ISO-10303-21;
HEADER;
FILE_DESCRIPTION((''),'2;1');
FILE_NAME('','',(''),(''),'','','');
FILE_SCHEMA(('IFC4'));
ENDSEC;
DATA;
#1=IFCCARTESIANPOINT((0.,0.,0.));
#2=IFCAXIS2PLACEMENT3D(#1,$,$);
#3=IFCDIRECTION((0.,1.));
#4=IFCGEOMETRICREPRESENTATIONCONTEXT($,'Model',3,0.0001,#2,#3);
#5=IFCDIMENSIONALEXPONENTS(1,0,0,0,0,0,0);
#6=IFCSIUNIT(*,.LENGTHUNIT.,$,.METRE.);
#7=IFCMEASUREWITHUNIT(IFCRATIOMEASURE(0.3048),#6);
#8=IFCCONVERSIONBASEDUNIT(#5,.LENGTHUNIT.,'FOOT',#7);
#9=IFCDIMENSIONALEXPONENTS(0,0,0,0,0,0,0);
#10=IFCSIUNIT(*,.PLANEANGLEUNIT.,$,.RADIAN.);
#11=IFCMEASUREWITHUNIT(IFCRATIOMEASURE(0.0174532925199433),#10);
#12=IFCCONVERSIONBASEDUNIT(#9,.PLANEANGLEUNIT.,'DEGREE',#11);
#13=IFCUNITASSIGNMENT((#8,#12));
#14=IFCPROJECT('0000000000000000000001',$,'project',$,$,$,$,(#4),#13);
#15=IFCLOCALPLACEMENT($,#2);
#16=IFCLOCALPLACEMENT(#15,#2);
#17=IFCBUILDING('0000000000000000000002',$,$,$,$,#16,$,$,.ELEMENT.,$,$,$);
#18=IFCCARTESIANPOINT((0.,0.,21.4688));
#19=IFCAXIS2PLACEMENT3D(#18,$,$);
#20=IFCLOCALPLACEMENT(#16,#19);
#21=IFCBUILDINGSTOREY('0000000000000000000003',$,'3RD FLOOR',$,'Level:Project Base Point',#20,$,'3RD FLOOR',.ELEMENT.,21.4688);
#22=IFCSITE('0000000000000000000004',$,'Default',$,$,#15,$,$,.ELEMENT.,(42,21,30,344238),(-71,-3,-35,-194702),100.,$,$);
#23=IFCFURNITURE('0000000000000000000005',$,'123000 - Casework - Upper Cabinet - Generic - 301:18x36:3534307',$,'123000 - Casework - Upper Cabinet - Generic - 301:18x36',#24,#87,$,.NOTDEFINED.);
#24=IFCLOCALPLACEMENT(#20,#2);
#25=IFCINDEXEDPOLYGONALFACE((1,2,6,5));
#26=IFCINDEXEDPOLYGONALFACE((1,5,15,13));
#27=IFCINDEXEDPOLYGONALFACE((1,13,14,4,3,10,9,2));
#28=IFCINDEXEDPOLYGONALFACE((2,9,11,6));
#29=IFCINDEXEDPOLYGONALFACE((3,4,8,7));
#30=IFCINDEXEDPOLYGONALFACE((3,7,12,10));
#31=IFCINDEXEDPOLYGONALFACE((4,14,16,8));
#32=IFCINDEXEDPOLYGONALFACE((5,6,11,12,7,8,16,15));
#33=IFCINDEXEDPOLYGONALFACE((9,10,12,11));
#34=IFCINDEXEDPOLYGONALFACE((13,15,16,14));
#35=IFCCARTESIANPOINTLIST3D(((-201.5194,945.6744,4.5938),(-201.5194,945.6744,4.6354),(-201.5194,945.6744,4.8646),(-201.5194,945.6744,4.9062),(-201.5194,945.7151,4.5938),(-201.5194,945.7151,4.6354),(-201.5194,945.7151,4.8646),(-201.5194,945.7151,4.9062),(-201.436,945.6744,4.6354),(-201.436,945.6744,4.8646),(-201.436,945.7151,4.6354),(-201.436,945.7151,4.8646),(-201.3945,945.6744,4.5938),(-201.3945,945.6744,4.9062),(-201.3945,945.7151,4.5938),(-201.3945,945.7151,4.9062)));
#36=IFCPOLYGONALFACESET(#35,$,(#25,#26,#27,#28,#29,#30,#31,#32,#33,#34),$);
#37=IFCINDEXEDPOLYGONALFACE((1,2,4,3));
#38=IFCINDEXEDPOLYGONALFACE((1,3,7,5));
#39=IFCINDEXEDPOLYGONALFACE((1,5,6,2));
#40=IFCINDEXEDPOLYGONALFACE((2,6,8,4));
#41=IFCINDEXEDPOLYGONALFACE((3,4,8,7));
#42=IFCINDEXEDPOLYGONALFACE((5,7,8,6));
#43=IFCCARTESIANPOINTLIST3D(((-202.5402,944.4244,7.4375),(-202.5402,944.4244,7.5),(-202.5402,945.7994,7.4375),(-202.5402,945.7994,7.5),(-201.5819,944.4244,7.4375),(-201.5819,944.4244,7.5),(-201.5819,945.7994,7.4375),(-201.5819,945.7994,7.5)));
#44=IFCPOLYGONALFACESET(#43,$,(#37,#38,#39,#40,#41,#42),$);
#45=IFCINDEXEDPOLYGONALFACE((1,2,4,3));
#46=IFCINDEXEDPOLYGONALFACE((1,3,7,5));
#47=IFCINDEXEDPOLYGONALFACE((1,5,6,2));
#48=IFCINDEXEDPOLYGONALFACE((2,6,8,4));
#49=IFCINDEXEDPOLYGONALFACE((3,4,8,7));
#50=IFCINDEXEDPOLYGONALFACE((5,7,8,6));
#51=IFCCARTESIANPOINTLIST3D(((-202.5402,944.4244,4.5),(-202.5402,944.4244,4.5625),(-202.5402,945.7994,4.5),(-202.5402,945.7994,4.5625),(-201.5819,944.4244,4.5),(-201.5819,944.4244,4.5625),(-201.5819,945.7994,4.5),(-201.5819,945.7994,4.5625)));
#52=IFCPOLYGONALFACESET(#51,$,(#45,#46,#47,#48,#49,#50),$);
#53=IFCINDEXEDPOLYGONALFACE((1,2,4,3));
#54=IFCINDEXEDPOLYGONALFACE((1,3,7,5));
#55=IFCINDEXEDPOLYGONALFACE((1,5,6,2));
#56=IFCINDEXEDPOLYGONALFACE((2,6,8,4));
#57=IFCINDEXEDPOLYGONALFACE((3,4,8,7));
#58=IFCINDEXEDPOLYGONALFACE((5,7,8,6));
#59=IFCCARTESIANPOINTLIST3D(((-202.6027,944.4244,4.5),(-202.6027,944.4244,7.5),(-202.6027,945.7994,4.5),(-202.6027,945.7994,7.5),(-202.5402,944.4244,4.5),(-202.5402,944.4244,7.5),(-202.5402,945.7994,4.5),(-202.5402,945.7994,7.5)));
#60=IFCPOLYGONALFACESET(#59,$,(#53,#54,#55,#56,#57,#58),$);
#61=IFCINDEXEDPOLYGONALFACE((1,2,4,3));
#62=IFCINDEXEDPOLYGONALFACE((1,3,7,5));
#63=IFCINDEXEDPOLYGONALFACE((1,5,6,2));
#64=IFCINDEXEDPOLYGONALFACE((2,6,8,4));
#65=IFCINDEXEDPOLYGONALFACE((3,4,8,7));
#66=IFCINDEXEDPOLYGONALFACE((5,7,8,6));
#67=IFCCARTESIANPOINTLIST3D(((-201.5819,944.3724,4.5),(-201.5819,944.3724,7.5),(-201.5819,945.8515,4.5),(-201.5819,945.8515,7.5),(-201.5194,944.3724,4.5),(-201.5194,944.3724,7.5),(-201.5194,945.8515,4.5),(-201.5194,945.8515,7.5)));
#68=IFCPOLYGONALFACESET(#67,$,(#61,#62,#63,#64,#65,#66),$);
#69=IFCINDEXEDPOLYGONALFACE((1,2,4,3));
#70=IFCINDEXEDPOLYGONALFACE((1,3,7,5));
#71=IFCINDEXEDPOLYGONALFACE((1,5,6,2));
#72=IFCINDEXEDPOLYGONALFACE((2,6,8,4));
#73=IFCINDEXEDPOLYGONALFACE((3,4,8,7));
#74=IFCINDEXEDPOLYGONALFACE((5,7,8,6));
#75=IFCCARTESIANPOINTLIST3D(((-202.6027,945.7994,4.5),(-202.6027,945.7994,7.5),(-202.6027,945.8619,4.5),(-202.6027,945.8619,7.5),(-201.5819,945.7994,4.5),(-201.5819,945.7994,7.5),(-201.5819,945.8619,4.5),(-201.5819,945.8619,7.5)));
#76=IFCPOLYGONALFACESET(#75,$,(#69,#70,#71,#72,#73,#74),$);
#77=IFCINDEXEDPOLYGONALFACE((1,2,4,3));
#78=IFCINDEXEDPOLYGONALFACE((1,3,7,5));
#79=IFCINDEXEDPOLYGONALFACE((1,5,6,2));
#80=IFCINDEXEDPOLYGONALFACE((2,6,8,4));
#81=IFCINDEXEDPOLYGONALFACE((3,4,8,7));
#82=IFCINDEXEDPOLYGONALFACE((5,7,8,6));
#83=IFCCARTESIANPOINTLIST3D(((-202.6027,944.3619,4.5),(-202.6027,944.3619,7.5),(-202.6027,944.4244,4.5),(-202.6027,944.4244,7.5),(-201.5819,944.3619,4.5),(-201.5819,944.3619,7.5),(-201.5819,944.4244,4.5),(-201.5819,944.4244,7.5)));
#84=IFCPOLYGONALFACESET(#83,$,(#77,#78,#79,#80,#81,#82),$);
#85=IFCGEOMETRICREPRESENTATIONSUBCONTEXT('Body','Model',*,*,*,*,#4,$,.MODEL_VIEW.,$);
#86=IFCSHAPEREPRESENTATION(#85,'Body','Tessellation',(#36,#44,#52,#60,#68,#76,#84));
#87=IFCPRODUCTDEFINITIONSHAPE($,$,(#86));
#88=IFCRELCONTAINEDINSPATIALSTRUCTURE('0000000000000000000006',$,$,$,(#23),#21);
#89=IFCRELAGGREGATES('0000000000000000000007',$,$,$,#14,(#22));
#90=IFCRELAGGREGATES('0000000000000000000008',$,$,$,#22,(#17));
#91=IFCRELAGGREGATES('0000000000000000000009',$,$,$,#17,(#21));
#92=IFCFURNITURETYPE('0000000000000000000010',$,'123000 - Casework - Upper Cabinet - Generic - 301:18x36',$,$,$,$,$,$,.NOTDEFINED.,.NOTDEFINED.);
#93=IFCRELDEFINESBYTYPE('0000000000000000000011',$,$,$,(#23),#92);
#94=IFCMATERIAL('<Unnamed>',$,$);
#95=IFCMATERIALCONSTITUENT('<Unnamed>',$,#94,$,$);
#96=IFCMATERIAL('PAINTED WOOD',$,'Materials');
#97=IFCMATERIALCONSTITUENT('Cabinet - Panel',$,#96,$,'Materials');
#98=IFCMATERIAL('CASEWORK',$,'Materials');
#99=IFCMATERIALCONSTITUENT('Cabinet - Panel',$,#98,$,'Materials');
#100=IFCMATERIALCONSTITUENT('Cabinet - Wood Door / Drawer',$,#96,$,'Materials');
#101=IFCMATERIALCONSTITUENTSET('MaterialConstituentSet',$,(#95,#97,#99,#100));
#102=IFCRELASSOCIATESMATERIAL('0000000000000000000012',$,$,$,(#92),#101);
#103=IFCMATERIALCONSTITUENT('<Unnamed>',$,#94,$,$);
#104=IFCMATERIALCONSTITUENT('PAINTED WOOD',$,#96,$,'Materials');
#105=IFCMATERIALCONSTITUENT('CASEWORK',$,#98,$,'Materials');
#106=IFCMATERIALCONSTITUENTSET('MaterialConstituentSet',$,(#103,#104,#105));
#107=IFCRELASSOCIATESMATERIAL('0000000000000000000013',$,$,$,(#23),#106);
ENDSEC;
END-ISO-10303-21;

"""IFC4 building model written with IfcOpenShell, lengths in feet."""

from ifc_helpers import new_model, entity, si_unit, converted_unit, direction, frame, frame_2d, origin, origin_2d_with_axis, place, context, subcontext, project, spatial, polyline, rectangle, outline, extrude, source, transform, mapped, material, constituent, constituent_set, type_object, type_shapes, element, save


model = new_model("IFC4")

# Units and contexts
model_context = context("Model", 3, precision=0.0001, world=origin(), true_north=direction((0.0, 1.0)))
body_context = subcontext(model_context, "Body", "Model", "MODEL_VIEW")
ifc_project = project(units=[converted_unit("LENGTHUNIT", "FOOT", entity("IfcRatioMeasure", 0.3048), si_unit("LENGTHUNIT", "METRE"), dimensions=[1, 0, 0, 0, 0, 0, 0]), converted_unit("PLANEANGLEUNIT", "DEGREE", entity("IfcRatioMeasure", 0.0174532925199433), si_unit("PLANEANGLEUNIT", "RADIAN"), dimensions=[0, 0, 0, 0, 0, 0, 0])], contexts=[model_context])

# Site, building, storey
site_placement = place(None, origin())
site = spatial("IfcSite", under=ifc_project, at=site_placement, Name="Default", CompositionType="ELEMENT", RefLatitude=(42, 21, 30, 344238), RefLongitude=(-71, -3, -35, -194702), RefElevation=100.0)
building_placement = place(site_placement, origin())
building = spatial("IfcBuilding", under=site, at=building_placement, CompositionType="ELEMENT")
storey_placement = place(building_placement, frame((0.0, 0.0, 21.4688)))
storey = spatial("IfcBuildingStorey", under=building, at=storey_placement, Name="3RD FLOOR", ObjectType="Level:Project Base Point", LongName="3RD FLOOR", CompositionType="ELEMENT", Elevation=21.4688)

# Furniture
ifc_material_1 = material(Name="PAINTED WOOD", Category="Materials")
ifc_material_2 = material(Name="CASEWORK", Category="Materials")
ifc_material_3 = material(Name="<Unnamed>")
ifc_constituent_1 = constituent(ifc_material_3, Name="<Unnamed>")
ifc_constituent_2 = constituent(ifc_material_1, Name="PAINTED WOOD", Category="Materials")
ifc_constituent_3 = constituent(ifc_material_2, Name="CASEWORK", Category="Materials")
ifc_constituent_set_1 = constituent_set(constituents=[ifc_constituent_1, ifc_constituent_2, ifc_constituent_3], Name="MaterialConstituentSet")
ifc_constituent_4 = constituent(ifc_material_3, Name="<Unnamed>")
ifc_constituent_5 = constituent(ifc_material_1, Name="Cabinet - Panel", Category="Materials")
ifc_constituent_6 = constituent(ifc_material_2, Name="Cabinet - Panel", Category="Materials")
ifc_constituent_7 = constituent(ifc_material_1, Name="Cabinet - Wood Door / Drawer", Category="Materials")
ifc_constituent_set_2 = constituent_set(constituents=[ifc_constituent_4, ifc_constituent_5, ifc_constituent_6, ifc_constituent_7], Name="MaterialConstituentSet")
furniture_type_1 = type_object("IfcFurnitureType", Name="123000 - Casework - Upper Cabinet - Generic - 301:18x36", AssemblyPlace="NOTDEFINED", PredefinedType="NOTDEFINED", material=ifc_constituent_set_2)
shared_shape_1 = source(origin(), body_context, "Body", "SweptSolid", [
    extrude(outline(polyline([(-0.0521, -0.1146), (-0.0521, -0.1562), (0.0729, -0.1562), (0.0729, 0.1562), (-0.0521, 0.1562), (-0.0521, 0.1146), (0.0313, 0.1146), (0.0313, -0.1146), (-0.0521, -0.1146)])), frame((0.1468, 1.1354, 0.25), z_axis=(-1.0, 0.0, 0.0), x_axis=(0.0, 1.0, 0.0)), (0.0, 0.0, -1.0), 0.0407),
    extrude(rectangle(XDim=0.9583, YDim=1.375, at=frame_2d((0.0, 0.0), x_axis=(1.0, 0.0))), frame((0.75, 0.5417, 2.9375), z_axis=(0.0, 0.0, 1.0), x_axis=(0.0, 1.0, 0.0)), (0.0, 0.0, 1.0), 0.0625),
    extrude(rectangle(XDim=0.9583, YDim=1.375, at=frame_2d((0.0, 0.0), x_axis=(1.0, 0.0))), frame((0.75, 0.5417, 0.0), z_axis=(0.0, 0.0, 1.0), x_axis=(0.0, 1.0, 0.0)), (0.0, 0.0, 1.0), 0.0625),
    extrude(rectangle(XDim=1.375, YDim=0.0625, at=origin_2d_with_axis()), frame((0.75, 0.0313, 0.0), z_axis=(0.0, 0.0, 1.0), x_axis=(-1.0, 0.0, 0.0)), (0.0, 0.0, 1.0), 3.0),
    extrude(rectangle(XDim=1.4792, YDim=0.0625, at=origin_2d_with_axis()), frame((0.75, 1.0521, 0.0)), (0.0, 0.0, 1.0), 3.0),
    extrude(rectangle(XDim=1.0208, YDim=0.0625, at=origin_2d_with_axis()), frame((0.0312, 0.5104, 0.0), z_axis=(0.0, 0.0, 1.0), x_axis=(0.0, 1.0, 0.0)), (0.0, 0.0, 1.0), 3.0),
    extrude(rectangle(XDim=1.0208, YDim=0.0625, at=origin_2d_with_axis()), frame((1.4688, 0.5104, 0.0), z_axis=(0.0, 0.0, 1.0), x_axis=(0.0, 1.0, 0.0)), (0.0, 0.0, 1.0), 3.0),
])
type_shapes(furniture_type_1, [shared_shape_1])
furniture_1_placement = place(storey_placement, frame((-202.6027, 945.8619, 4.5), z_axis=(0.0, 0.0, 1.0), x_axis=(0.0, -1.0, 0.0)))
element("IfcFurniture", 1, at=furniture_1_placement, inside=storey, type_object=furniture_type_1, material=ifc_constituent_set_1, Name="123000 - Casework - Upper Cabinet - Generic - 301:18x36:3534307", ObjectType="123000 - Casework - Upper Cabinet - Generic - 301:18x36", PredefinedType="NOTDEFINED", context=body_context, shape_type="MappedRepresentation", body=[
    mapped(shared_shape_1, transform((0.0, 0.0, 0.0), scale=1.0)),
])

save(model, "model.ifc")
